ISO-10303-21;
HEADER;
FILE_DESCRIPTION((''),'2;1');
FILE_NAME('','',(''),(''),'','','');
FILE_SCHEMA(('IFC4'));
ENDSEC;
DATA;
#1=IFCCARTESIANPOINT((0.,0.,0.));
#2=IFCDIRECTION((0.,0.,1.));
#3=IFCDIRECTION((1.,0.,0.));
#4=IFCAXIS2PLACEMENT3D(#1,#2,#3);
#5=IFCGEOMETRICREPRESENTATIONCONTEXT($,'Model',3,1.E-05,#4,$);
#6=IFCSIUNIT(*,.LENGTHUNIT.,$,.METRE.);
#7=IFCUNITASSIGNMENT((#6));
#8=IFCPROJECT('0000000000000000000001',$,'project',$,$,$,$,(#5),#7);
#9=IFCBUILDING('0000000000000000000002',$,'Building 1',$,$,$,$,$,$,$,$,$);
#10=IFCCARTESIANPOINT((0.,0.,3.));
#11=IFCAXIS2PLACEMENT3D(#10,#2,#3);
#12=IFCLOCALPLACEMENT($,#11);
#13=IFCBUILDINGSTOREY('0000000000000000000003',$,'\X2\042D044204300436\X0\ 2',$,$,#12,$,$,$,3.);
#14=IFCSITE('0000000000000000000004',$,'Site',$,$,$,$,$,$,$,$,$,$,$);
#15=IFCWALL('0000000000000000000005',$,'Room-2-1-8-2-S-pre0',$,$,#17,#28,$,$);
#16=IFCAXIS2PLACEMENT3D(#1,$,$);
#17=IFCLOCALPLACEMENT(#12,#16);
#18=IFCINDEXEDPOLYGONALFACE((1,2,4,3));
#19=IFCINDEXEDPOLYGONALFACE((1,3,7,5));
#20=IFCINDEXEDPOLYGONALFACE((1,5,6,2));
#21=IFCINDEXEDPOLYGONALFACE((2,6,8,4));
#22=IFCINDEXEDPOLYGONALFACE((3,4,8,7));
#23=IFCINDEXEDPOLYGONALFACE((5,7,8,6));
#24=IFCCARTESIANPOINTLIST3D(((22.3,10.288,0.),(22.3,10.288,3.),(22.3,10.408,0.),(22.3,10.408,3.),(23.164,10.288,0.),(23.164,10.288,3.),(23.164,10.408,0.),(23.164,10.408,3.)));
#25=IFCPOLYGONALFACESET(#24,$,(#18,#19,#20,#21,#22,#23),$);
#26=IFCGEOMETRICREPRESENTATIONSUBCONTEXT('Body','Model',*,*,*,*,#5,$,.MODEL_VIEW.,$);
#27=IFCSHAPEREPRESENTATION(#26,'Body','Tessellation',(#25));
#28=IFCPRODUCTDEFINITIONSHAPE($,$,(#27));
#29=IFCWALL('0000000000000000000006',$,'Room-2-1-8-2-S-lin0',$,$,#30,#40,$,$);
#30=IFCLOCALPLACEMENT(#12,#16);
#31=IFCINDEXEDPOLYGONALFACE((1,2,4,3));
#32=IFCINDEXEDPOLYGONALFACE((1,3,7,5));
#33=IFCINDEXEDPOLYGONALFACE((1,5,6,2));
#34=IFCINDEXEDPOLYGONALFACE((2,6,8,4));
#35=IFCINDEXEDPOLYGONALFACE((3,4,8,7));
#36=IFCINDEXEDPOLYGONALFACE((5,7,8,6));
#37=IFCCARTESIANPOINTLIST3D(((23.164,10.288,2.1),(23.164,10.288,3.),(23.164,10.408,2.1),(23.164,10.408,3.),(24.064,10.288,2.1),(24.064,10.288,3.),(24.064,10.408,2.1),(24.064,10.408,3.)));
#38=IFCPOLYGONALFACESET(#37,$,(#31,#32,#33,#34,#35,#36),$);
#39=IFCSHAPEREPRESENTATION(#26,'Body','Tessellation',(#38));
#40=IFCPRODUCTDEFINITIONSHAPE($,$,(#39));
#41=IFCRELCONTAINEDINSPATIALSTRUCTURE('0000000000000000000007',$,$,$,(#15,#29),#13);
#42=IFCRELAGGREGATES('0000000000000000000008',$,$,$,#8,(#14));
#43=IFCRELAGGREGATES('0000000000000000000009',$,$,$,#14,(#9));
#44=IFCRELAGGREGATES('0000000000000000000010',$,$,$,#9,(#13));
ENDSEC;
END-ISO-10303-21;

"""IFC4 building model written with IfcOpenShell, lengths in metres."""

from ifc_helpers import new_model, si_unit, frame, origin_with_axes, place, context, subcontext, project, spatial, indexed_curve, outline, extrude, element, save


model = new_model("IFC4")

# Units and contexts
model_context = context("Model", 3, precision=1e-05, world=origin_with_axes())
body_context = subcontext(model_context, "Body", "Model", "MODEL_VIEW")
ifc_project = project(units=[si_unit("LENGTHUNIT", "METRE")], contexts=[model_context])

# Site, building, storey
site = spatial("IfcSite", under=ifc_project, Name="Site")
building = spatial("IfcBuilding", under=site, Name="Building 1")
storey_placement = place(None, frame((0.0, 0.0, 3.0), z_axis=(0.0, 0.0, 1.0), x_axis=(1.0, 0.0, 0.0)))
storey = spatial("IfcBuildingStorey", under=building, at=storey_placement, Name="Этаж 2", Elevation=3.0)

# Walls
wall_1_placement = place(storey_placement, frame((22.3, 10.288, 0.0), z_axis=(0.0, 0.0, 1.0), x_axis=(1.0, 0.0, 0.0)))
element("IfcWall", 1, at=wall_1_placement, inside=storey, Name="Room-2-1-8-2-S-pre0", context=body_context, shape_type="SweptSolid", body=[
    extrude(outline(indexed_curve([(0.0, 0.0), (0.0, 0.12), (0.864, 0.12), (0.864, 0.0), (0.0, 0.0)], self_intersect=False)), origin_with_axes(), (0.0, 0.0, 1.0), 3.0),
])
wall_2_placement = place(storey_placement, frame((23.164, 10.288, 2.1), z_axis=(0.0, 0.0, 1.0), x_axis=(1.0, 0.0, 0.0)))
element("IfcWall", 2, at=wall_2_placement, inside=storey, Name="Room-2-1-8-2-S-lin0", context=body_context, shape_type="SweptSolid", body=[
    extrude(outline(indexed_curve([(0.0, 0.0), (0.0, 0.12), (0.9, 0.12), (0.9, 0.0), (0.0, 0.0)], self_intersect=False)), origin_with_axes(), (0.0, 0.0, 1.0), 0.9),
])

save(model, "model.ifc")
